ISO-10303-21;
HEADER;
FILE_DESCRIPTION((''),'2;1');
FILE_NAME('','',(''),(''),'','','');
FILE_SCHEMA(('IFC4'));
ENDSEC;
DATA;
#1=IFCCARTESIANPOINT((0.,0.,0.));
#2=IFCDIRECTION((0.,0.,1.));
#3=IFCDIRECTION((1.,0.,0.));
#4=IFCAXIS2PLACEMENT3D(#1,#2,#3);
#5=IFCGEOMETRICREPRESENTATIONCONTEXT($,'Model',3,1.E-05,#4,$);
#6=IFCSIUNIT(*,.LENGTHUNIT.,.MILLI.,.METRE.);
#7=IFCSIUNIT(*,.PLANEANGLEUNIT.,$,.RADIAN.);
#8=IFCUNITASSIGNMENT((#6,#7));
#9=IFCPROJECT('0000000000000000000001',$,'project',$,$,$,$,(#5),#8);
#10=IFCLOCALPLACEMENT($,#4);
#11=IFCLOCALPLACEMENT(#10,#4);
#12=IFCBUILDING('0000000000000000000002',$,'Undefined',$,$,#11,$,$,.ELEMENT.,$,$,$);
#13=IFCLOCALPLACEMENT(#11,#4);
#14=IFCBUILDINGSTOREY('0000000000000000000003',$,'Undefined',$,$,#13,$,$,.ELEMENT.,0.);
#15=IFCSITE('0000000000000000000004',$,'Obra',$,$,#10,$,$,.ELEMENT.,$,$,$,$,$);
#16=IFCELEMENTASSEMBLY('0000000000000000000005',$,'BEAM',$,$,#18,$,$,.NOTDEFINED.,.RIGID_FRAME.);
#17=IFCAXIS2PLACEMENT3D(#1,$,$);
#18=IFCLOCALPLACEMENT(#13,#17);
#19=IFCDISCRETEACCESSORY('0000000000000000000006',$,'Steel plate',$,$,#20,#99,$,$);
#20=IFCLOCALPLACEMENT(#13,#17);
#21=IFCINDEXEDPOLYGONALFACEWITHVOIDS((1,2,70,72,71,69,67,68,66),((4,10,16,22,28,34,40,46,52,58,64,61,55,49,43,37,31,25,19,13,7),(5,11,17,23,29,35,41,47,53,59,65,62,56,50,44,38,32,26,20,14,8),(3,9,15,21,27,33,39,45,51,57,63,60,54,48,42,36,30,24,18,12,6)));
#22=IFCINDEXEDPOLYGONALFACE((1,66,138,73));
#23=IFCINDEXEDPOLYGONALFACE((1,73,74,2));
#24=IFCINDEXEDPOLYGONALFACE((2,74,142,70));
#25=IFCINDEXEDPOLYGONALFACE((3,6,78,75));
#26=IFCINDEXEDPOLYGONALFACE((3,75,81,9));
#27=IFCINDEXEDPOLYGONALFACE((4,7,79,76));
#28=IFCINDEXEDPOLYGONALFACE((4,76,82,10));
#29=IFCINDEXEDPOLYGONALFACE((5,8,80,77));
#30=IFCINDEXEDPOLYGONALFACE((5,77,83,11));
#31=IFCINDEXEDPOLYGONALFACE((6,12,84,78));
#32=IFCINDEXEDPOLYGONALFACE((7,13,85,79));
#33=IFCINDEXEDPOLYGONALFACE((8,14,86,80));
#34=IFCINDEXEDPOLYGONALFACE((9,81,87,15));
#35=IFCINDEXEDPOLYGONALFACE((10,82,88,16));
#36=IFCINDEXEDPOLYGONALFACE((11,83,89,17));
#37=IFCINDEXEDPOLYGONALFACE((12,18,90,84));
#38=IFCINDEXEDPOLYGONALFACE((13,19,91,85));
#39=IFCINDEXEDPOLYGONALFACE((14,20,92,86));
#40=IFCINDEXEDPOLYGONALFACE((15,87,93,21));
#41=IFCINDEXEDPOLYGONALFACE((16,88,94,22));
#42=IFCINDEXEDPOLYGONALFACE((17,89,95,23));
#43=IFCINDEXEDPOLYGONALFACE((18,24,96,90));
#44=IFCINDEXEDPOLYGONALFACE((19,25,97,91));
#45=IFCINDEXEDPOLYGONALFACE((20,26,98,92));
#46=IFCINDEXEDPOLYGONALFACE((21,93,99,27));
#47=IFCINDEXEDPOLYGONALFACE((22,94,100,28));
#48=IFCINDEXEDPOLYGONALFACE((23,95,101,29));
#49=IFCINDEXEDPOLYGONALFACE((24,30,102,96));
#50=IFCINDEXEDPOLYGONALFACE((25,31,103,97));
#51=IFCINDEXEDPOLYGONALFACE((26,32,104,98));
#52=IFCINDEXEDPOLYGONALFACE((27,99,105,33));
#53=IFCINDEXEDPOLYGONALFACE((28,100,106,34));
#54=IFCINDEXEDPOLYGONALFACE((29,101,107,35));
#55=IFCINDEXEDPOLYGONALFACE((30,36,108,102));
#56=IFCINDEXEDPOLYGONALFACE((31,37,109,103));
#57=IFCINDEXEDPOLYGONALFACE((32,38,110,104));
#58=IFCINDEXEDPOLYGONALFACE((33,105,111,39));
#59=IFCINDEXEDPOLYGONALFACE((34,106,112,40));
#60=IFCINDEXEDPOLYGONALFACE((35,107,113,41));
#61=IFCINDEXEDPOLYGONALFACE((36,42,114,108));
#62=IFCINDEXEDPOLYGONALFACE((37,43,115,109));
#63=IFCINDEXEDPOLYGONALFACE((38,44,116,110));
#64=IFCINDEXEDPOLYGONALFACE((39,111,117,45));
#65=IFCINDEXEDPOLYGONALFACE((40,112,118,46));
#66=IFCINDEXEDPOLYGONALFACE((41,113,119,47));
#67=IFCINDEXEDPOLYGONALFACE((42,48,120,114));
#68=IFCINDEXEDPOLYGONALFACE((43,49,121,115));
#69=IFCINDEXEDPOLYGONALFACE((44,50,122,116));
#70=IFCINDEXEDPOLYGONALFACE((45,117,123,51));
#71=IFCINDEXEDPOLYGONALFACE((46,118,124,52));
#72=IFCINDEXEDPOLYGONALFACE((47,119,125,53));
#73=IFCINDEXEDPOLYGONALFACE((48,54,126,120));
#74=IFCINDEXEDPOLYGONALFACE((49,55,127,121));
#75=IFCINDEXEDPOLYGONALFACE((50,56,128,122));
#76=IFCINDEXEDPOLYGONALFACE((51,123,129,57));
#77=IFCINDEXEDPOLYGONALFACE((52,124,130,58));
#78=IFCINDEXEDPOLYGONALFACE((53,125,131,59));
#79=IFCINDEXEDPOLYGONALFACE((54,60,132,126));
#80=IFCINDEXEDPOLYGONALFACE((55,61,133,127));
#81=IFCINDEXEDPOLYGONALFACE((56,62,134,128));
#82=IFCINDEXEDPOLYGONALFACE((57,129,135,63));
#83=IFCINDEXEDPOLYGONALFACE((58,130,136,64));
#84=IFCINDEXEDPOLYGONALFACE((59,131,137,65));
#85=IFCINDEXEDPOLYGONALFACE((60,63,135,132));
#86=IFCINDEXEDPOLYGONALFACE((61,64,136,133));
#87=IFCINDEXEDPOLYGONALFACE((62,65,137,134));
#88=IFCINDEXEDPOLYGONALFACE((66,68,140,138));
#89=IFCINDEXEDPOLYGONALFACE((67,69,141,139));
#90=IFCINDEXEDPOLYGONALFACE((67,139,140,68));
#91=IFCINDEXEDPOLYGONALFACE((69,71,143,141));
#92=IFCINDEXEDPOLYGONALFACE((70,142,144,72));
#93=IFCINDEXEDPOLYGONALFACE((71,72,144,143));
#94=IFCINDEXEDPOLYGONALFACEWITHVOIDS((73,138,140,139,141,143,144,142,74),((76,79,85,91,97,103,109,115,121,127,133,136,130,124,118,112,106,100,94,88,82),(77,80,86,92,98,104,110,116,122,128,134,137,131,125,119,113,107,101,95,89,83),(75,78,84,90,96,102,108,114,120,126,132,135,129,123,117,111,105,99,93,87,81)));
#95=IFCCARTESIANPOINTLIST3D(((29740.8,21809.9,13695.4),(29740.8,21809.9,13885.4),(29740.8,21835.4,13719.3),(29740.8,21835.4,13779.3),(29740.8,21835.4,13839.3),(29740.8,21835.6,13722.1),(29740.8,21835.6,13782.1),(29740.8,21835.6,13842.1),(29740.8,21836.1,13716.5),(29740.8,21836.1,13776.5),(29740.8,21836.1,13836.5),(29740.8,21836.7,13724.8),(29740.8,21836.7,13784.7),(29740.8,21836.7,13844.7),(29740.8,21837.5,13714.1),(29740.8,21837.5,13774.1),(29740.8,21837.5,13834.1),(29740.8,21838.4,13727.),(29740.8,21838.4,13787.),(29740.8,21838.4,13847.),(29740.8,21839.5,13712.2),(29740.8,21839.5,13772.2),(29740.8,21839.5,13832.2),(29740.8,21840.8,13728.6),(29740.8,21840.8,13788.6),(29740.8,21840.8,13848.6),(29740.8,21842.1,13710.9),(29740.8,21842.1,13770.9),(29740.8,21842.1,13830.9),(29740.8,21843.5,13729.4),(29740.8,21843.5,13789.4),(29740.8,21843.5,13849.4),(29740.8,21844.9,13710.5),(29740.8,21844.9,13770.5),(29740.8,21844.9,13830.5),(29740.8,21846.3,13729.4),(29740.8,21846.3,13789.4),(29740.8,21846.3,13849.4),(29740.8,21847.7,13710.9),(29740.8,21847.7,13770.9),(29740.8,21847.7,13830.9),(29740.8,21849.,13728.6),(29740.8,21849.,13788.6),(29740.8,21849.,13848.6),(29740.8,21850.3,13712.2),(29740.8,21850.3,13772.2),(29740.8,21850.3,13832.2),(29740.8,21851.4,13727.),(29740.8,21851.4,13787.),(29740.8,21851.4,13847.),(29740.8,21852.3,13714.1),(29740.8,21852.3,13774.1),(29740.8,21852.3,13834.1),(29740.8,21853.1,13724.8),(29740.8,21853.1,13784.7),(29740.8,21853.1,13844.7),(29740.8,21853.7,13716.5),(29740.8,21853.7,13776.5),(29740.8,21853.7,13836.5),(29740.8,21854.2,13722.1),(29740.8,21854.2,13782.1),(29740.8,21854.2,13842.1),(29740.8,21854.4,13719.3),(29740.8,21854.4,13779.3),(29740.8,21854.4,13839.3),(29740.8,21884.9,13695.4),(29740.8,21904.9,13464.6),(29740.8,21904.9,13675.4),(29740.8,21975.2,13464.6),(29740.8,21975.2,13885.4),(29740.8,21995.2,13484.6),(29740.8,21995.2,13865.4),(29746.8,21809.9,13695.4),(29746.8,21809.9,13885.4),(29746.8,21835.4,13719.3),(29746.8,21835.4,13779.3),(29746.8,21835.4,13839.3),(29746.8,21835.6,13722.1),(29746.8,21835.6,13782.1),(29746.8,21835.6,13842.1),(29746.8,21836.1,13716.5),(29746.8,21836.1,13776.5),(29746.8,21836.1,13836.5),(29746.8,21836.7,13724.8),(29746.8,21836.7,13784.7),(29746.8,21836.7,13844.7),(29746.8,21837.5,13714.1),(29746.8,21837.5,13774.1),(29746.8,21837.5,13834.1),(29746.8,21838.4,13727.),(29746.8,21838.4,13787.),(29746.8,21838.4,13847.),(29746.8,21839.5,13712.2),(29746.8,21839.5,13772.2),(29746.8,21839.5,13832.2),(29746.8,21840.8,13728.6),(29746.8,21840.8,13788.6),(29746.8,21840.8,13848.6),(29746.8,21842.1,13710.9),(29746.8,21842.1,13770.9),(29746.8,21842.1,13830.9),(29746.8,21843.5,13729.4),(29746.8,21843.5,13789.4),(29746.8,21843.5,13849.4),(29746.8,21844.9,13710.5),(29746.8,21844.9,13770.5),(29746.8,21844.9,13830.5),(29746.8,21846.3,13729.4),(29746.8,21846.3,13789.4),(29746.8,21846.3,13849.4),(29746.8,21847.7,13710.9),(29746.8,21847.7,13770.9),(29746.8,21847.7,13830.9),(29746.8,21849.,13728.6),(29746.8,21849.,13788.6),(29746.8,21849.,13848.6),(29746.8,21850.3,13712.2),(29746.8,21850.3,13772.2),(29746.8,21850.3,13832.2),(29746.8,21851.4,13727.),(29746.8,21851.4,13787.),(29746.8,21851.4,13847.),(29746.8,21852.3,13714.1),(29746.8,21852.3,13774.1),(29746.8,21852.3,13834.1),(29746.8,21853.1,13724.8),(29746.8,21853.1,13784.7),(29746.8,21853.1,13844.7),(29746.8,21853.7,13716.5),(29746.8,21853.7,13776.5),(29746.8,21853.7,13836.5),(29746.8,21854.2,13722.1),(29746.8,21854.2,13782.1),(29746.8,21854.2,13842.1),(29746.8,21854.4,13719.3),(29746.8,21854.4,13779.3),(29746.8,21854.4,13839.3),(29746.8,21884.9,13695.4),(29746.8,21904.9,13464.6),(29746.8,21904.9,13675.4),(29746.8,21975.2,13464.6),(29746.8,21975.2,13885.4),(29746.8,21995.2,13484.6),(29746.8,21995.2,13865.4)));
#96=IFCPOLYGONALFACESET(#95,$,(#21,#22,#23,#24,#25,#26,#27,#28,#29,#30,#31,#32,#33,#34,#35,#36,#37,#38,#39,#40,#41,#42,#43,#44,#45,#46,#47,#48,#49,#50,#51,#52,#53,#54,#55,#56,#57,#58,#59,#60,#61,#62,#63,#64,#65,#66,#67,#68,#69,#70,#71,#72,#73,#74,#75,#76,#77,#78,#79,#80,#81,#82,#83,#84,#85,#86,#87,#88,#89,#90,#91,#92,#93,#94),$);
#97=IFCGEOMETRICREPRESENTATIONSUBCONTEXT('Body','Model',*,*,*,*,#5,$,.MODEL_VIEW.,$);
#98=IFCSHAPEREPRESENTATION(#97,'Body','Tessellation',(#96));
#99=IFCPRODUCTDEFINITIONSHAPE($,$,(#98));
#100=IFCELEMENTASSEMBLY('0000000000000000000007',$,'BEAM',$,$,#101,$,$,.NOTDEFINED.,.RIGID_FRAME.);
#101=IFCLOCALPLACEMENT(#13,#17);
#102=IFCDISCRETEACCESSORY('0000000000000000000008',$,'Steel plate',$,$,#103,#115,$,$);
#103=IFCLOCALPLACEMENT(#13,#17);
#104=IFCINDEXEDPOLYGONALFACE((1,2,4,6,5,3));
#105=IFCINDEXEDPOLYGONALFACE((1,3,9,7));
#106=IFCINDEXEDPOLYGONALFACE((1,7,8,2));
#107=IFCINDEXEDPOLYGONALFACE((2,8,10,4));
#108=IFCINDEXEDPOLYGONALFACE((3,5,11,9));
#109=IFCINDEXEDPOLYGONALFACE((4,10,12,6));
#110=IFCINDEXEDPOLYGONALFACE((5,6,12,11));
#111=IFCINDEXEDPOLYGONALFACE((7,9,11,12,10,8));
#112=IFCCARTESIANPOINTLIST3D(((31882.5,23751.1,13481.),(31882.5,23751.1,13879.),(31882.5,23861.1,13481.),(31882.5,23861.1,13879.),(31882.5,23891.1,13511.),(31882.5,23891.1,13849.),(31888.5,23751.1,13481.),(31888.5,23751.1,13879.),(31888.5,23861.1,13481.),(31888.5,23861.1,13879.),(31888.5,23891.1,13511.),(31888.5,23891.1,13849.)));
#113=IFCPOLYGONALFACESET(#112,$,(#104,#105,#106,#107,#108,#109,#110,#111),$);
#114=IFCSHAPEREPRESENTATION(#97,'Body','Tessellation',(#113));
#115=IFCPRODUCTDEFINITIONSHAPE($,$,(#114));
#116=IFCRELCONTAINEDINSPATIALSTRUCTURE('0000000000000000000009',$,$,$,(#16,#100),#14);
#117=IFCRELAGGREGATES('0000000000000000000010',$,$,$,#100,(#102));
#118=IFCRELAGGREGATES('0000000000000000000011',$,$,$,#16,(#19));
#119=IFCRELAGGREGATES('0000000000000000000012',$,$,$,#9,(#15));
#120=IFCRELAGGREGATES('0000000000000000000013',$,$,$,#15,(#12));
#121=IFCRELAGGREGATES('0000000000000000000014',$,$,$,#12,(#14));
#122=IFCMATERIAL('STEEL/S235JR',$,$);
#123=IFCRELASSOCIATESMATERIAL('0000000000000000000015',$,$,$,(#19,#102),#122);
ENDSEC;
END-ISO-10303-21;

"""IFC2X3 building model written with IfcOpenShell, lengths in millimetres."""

from ifc_helpers import new_model, si_unit, frame, origin_with_axes, origin_2d_with_axis, place, context, subcontext, project, spatial, polyline, circle, outline, extrude, source, transform, mapped, material, element, aggregate, save


model = new_model("IFC2X3")

# Units and contexts
model_context = context("Model", 3, precision=1e-05, world=origin_with_axes())
body_context = subcontext(model_context, "Body", "Model", "MODEL_VIEW")
ifc_project = project(units=[si_unit("LENGTHUNIT", "METRE", prefix="MILLI"), si_unit("PLANEANGLEUNIT", "RADIAN")], contexts=[model_context])

# Site, building, storey
site_placement = place(None, origin_with_axes())
site = spatial("IfcSite", under=ifc_project, at=site_placement, Name="Obra", CompositionType="ELEMENT")
building_placement = place(site_placement, origin_with_axes())
building = spatial("IfcBuilding", under=site, at=building_placement, Name="Undefined", CompositionType="ELEMENT")
storey_placement = place(building_placement, origin_with_axes())
storey = spatial("IfcBuildingStorey", under=building, at=storey_placement, Name="Undefined", CompositionType="ELEMENT", Elevation=0.0)

# Shared definitions
ifc_material_1 = material(Name="STEEL/S235JR")

# Element assembly
assembly_1_placement = place(storey_placement, origin_with_axes())
assembly_1 = element("IfcElementAssembly", 1, at=assembly_1_placement, inside=storey, Name="BEAM", AssemblyPlace="NOTDEFINED", PredefinedType="RIGID_FRAME")

# Discrete accessory, opening
discrete_accessory_1_placement = place(assembly_1_placement, frame((29743.8, 21995.2, 13484.6), z_axis=(-1.0, 0.0, 0.0), x_axis=(0.000001, -0.707107, -0.707107)))
discrete_accessory_1 = element("IfcDiscreteAccessory", 2, at=discrete_accessory_1_placement, material=ifc_material_1, Name="Steel plate", context=body_context, shape_type="SweptSolid", body=[
    extrude(outline(polyline([(0.0, 0.0), (28.3, 0.0), (78.0, 49.7), (-71.1, 198.8), (-71.1, 227.1), (-18.0, 280.1), (-152.4, 414.4), (-269.3, 297.6), (-269.3, 269.3), (0.0, 0.0)])), frame((0.0, 0.0, -3.0), z_axis=(0.0, 0.0, 1.0), x_axis=(1.0, 0.0, 0.0)), (0.0, 0.0, 1.0), 6.0),
])
shared_shape_1 = source(origin_with_axes(), body_context, "Body", "SweptSolid", [
    extrude(circle(Radius=9.5, at=origin_2d_with_axis()), frame((0.0, -9.2, 0.0), z_axis=(0.0, 1.0, 0.0), x_axis=(1.0, 0.0, 0.0)), (0.0, 0.0, 1.0), 6.2),
])
opening_1_placement = place(assembly_1_placement, frame((29749.9, 21894.9, 13885.4), z_axis=(0.0, -1.0, 0.0), x_axis=(0.0, 0.0, -1.0)))
element("IfcOpeningElement", 3, at=opening_1_placement, cuts=discrete_accessory_1, ObjectType="Opening", context=body_context, shape_type="MappedRepresentation", body=[
    mapped(shared_shape_1, transform((165.4, 0.0, 50.0))),
    mapped(shared_shape_1, transform((105.4, 0.0, 50.0))),
    mapped(shared_shape_1, transform((45.4, 0.0, 50.0))),
])

# Element assembly, discrete accessory
assembly_2_placement = place(storey_placement, origin_with_axes())
assembly_2 = element("IfcElementAssembly", 4, at=assembly_2_placement, inside=storey, Name="BEAM", AssemblyPlace="NOTDEFINED", PredefinedType="RIGID_FRAME")
discrete_accessory_2_placement = place(assembly_2_placement, frame((31885.5, 23891.1, 13481.0), z_axis=(-1.0, 0.0, 0.0), x_axis=(0.0, -1.0, 0.0)))
discrete_accessory_2 = element("IfcDiscreteAccessory", 5, at=discrete_accessory_2_placement, material=ifc_material_1, Name="Steel plate", context=body_context, shape_type="SweptSolid", body=[
    extrude(outline(polyline([(0.0, 30.0), (30.0, 0.0), (140.0, 0.0), (140.0, 398.0), (30.0, 398.0), (0.0, 368.0), (0.0, 30.0)])), frame((0.0, 0.0, -3.0), z_axis=(0.0, 0.0, 1.0), x_axis=(1.0, 0.0, 0.0)), (0.0, 0.0, 1.0), 6.0),
])
aggregate(assembly_2, [discrete_accessory_2])

aggregate(assembly_1, [discrete_accessory_1])

save(model, "model.ifc")
